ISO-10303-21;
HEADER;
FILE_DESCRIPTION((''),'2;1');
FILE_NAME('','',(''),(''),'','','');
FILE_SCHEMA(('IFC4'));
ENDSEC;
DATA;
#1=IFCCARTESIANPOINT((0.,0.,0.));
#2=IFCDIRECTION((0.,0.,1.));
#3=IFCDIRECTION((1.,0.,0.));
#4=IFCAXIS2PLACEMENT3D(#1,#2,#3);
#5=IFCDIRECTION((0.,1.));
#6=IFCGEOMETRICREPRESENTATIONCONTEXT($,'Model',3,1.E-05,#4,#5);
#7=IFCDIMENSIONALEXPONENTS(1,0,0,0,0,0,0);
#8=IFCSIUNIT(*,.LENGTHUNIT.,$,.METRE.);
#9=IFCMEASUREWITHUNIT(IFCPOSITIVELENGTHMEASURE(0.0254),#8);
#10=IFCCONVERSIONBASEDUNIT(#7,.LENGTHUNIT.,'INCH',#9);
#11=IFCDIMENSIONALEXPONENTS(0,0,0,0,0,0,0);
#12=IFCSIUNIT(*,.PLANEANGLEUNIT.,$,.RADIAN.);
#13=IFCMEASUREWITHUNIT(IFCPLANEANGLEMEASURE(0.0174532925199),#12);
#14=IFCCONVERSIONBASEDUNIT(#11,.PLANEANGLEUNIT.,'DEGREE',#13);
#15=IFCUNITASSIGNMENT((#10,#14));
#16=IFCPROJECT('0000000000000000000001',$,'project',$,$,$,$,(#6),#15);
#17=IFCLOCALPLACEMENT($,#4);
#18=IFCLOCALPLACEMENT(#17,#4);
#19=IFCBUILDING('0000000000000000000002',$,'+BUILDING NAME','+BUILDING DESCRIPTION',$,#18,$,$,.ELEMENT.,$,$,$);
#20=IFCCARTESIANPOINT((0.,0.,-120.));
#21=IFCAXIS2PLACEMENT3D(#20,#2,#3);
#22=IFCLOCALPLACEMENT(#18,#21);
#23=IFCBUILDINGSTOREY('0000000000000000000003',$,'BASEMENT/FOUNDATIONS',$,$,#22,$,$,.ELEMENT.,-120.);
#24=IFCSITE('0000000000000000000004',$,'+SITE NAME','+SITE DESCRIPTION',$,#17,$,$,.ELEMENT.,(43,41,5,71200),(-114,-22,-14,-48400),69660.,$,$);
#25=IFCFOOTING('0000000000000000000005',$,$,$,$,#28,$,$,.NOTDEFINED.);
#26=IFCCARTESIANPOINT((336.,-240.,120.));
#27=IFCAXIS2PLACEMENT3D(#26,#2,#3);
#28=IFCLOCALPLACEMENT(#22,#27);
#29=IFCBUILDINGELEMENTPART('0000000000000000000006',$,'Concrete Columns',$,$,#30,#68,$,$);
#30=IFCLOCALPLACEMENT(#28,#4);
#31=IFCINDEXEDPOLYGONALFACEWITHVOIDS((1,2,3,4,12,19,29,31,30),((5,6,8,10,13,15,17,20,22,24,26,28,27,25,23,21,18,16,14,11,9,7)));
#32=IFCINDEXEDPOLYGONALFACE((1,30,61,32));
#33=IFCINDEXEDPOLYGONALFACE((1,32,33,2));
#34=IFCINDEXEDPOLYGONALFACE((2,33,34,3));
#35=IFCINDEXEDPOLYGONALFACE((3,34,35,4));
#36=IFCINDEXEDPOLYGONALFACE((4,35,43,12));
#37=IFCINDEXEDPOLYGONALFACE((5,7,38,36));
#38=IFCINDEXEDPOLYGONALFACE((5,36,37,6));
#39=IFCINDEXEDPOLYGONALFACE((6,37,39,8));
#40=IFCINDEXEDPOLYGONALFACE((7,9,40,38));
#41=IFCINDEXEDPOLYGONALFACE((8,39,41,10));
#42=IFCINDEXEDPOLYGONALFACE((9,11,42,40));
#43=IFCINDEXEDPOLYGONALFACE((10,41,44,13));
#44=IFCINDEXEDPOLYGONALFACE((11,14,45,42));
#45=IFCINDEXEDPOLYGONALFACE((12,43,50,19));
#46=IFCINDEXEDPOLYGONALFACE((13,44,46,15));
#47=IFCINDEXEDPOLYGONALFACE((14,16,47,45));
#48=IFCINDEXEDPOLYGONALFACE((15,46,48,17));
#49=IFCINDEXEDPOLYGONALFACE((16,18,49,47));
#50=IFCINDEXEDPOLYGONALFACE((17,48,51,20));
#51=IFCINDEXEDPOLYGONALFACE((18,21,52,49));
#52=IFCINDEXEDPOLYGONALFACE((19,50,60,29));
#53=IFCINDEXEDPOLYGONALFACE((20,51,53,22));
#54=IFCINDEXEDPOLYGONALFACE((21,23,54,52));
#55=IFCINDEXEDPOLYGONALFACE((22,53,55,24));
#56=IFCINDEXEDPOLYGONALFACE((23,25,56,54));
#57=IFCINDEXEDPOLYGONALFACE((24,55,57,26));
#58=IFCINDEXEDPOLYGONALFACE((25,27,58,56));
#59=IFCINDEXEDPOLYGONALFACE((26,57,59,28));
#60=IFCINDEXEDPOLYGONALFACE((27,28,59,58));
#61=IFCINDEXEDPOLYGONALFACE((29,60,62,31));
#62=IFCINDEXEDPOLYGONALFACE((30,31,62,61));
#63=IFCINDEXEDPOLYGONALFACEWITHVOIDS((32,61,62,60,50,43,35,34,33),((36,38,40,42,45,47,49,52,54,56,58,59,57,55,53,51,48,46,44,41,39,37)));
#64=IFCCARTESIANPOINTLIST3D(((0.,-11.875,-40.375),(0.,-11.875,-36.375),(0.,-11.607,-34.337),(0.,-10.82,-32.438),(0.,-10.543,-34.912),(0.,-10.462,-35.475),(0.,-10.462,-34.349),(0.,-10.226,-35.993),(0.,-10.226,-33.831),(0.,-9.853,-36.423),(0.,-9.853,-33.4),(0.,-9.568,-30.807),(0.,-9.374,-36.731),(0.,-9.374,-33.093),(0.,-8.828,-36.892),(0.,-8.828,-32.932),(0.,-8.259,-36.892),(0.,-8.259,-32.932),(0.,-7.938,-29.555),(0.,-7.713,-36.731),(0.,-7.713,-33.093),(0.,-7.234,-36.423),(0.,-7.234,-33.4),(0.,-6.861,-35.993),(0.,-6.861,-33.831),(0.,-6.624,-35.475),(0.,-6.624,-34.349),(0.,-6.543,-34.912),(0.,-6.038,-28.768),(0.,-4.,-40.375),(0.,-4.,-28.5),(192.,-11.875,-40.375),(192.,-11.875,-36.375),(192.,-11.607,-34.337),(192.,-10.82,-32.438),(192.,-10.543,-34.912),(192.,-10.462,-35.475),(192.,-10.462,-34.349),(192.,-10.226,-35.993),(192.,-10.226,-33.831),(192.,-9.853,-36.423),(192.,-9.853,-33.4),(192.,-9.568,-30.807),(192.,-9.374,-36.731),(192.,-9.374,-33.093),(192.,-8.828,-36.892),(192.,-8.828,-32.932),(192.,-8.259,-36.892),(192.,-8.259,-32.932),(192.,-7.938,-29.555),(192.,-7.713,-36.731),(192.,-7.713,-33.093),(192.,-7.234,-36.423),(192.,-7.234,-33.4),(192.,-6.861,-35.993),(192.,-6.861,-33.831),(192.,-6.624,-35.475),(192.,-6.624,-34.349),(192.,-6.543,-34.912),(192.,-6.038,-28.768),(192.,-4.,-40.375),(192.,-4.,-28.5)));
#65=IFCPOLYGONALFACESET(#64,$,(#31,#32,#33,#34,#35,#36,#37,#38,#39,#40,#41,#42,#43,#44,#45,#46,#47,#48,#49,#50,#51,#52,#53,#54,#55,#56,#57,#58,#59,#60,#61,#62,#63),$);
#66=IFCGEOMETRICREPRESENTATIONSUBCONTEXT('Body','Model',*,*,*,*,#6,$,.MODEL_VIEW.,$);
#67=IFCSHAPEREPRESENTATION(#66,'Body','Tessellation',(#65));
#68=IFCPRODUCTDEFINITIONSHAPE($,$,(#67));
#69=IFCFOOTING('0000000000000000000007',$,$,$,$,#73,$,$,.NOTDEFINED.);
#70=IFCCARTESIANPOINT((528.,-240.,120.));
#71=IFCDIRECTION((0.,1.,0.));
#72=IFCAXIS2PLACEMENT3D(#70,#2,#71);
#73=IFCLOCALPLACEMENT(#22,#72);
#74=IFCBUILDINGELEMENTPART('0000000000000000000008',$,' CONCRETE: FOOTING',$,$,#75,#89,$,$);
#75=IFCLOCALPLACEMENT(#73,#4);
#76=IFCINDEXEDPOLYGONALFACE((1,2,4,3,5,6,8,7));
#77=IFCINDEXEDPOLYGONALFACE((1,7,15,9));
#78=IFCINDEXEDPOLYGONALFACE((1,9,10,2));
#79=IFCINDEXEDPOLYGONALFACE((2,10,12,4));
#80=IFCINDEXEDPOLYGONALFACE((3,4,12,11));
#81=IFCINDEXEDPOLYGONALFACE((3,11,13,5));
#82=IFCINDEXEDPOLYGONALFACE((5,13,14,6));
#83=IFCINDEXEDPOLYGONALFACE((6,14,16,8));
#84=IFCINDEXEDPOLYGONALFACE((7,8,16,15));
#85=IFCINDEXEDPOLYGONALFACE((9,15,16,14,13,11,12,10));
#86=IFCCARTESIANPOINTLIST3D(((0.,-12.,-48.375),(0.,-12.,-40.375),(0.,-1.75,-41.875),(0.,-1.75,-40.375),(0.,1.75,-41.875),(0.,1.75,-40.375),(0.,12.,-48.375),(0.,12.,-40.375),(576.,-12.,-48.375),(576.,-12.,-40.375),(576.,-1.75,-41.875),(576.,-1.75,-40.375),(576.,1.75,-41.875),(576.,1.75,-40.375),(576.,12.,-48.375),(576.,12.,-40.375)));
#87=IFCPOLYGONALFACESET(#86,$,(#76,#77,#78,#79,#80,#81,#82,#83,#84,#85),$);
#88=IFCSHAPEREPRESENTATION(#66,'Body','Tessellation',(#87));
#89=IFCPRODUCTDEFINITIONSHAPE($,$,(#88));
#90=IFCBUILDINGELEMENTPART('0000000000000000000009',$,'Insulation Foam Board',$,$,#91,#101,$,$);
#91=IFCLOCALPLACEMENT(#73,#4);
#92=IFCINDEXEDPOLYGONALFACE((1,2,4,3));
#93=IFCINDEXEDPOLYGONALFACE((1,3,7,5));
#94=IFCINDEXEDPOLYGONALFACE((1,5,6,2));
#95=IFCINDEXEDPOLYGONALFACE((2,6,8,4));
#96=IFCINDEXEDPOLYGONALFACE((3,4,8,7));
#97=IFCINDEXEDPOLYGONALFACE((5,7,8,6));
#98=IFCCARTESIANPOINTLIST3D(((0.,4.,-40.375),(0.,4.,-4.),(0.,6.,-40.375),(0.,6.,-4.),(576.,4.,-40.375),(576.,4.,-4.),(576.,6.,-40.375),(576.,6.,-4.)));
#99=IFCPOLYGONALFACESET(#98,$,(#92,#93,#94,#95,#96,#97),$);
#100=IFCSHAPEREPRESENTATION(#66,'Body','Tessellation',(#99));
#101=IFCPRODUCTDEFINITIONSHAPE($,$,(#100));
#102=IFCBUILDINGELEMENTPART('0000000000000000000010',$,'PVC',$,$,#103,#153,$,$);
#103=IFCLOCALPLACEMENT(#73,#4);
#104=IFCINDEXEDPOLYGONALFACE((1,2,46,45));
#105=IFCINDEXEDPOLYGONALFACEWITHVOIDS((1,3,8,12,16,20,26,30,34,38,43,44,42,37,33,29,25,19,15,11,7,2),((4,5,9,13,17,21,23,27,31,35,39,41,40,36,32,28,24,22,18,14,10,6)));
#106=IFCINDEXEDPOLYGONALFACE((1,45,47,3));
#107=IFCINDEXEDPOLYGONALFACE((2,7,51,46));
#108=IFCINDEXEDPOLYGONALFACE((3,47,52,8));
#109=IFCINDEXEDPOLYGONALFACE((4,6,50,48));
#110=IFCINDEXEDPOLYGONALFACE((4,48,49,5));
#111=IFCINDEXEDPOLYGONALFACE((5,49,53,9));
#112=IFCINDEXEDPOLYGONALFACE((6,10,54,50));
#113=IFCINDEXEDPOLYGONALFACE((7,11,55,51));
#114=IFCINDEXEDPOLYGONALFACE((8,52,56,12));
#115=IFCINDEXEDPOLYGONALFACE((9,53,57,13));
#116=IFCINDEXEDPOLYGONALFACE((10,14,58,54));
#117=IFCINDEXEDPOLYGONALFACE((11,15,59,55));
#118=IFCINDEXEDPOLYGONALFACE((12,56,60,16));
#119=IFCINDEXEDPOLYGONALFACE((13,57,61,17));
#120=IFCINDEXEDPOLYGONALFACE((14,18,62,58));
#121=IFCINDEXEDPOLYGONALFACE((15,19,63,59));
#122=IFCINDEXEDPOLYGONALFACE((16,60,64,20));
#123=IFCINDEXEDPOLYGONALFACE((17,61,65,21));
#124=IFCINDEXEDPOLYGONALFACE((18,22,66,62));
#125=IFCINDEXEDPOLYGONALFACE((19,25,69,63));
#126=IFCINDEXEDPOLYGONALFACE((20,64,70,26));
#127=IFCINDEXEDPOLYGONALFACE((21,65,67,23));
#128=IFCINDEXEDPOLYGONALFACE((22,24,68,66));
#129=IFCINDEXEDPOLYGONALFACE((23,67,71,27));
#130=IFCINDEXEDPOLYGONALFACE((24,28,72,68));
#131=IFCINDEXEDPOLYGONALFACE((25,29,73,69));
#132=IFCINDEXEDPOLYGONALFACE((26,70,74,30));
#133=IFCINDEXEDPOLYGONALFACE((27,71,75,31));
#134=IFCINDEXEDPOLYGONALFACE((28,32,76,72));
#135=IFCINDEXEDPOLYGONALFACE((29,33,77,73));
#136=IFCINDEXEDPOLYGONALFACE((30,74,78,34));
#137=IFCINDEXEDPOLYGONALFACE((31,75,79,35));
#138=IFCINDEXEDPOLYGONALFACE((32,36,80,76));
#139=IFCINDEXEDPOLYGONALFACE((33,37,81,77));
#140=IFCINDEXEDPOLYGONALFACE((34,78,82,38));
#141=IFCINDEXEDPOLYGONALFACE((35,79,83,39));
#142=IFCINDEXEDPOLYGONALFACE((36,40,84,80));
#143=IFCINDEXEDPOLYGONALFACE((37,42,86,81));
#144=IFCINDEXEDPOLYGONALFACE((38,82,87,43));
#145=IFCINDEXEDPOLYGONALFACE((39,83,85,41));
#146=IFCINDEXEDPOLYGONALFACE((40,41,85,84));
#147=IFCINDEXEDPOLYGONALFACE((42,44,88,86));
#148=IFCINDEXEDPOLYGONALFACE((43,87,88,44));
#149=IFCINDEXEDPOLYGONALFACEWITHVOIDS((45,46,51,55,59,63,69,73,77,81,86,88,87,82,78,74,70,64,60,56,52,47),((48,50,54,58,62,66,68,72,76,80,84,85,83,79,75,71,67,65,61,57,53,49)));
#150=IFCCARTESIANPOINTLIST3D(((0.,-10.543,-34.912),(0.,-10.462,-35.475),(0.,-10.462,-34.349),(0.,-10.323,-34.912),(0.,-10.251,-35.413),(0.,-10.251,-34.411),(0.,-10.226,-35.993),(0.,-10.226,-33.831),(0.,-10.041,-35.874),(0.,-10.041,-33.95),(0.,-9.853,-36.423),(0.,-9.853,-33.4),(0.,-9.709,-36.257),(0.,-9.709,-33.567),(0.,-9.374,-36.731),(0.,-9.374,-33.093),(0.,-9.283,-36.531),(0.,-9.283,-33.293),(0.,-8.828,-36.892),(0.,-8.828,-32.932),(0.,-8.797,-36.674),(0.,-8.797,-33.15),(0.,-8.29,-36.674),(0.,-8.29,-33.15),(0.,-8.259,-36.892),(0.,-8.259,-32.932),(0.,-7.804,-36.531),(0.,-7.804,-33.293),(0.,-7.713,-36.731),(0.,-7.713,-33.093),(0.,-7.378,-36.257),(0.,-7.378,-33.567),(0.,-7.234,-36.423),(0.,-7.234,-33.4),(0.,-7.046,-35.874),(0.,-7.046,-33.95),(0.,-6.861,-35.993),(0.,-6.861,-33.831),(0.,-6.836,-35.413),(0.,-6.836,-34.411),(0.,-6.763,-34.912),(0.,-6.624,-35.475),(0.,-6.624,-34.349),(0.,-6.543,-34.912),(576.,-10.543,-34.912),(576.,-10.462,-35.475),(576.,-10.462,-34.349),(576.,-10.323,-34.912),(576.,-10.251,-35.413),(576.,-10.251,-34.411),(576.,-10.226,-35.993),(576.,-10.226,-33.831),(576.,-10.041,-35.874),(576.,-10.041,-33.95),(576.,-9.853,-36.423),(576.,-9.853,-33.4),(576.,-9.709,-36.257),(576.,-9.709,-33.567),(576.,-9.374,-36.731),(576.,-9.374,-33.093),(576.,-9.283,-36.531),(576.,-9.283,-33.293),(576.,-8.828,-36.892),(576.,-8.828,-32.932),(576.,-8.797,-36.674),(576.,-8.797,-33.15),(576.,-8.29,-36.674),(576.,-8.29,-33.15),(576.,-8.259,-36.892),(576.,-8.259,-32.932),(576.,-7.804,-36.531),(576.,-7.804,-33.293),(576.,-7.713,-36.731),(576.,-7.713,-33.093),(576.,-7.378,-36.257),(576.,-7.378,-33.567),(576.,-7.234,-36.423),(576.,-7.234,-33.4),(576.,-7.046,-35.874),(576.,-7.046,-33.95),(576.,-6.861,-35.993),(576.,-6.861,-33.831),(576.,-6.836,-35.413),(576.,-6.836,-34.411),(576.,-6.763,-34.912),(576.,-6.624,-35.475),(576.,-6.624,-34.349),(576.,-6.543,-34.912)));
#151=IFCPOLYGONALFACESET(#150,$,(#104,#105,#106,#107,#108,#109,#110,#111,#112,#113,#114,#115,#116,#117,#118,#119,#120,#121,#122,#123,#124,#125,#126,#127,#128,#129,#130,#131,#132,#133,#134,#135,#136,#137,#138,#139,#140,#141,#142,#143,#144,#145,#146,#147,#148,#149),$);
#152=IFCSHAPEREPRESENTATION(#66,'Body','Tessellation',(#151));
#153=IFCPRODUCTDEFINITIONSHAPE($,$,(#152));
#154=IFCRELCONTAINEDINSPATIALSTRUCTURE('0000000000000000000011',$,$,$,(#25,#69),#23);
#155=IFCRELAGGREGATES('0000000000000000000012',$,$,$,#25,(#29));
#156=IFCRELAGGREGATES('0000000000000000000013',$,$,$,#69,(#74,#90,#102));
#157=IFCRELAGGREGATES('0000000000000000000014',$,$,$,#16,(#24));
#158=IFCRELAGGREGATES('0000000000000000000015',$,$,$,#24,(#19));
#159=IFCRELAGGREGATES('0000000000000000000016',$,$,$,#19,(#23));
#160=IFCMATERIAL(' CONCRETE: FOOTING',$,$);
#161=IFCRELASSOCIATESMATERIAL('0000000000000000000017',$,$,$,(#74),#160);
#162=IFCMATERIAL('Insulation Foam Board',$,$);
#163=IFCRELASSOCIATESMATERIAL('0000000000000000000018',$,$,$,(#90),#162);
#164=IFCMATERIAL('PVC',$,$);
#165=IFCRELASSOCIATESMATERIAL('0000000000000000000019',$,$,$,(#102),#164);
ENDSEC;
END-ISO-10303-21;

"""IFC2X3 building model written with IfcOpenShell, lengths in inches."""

from ifc_helpers import new_model, entity, si_unit, converted_unit, point, direction, frame, frame_2d, origin_with_axes, place, context, subcontext, project, spatial, polyline, circle_curve, parameter, trimmed, segment, composite_curve, outline, extrude, material, element, aggregate, save


model = new_model("IFC2X3")

# Units and contexts
model_context = context("Model", 3, precision=1e-05, world=origin_with_axes(), true_north=direction((0.0, 1.0)))
body_context = subcontext(model_context, "Body", "Model", "MODEL_VIEW")
ifc_project = project(units=[converted_unit("LENGTHUNIT", "INCH", entity("IfcPositiveLengthMeasure", 0.0254), si_unit("LENGTHUNIT", "METRE"), dimensions=[1, 0, 0, 0, 0, 0, 0]), converted_unit("PLANEANGLEUNIT", "DEGREE", entity("IfcPlaneAngleMeasure", 0.0174532925199), si_unit("PLANEANGLEUNIT", "RADIAN"), dimensions=[0, 0, 0, 0, 0, 0, 0])], contexts=[model_context])

# Site, building, storey
site_placement = place(None, origin_with_axes())
site = spatial("IfcSite", under=ifc_project, at=site_placement, Name="+SITE NAME", Description="+SITE DESCRIPTION", CompositionType="ELEMENT", RefLatitude=(43, 41, 5, 71200), RefLongitude=(-114, -22, -14, -48400), RefElevation=69660.0)
building_placement = place(site_placement, origin_with_axes())
building = spatial("IfcBuilding", under=site, at=building_placement, Name="+BUILDING NAME", Description="+BUILDING DESCRIPTION", CompositionType="ELEMENT")
storey_placement = place(building_placement, frame((0.0, 0.0, -120.0), z_axis=(0.0, 0.0, 1.0), x_axis=(1.0, 0.0, 0.0)))
storey = spatial("IfcBuildingStorey", under=building, at=storey_placement, Name="BASEMENT/FOUNDATIONS", CompositionType="ELEMENT", Elevation=-120.0)

# Footings, building element parts
ifc_material_1 = material(Name=" CONCRETE: FOOTING")
ifc_material_2 = material(Name="Insulation Foam Board")
ifc_material_3 = material(Name="PVC")
footing_1_placement = place(storey_placement, frame((336.0, -240.0, 120.0), z_axis=(0.0, 0.0, 1.0), x_axis=(1.0, 0.0, 0.0)))
footing_1 = element("IfcFooting", 1, at=footing_1_placement, inside=storey, PredefinedType="NOTDEFINED")
building_element_part_1_placement = place(footing_1_placement, origin_with_axes())
building_element_part_1 = element("IfcBuildingElementPart", 2, at=building_element_part_1_placement, Name="Concrete Columns", context=body_context, shape_type="SweptSolid", body=[
    extrude(outline(composite_curve([segment(trimmed(circle_curve(frame_2d((4.0, -36.375), x_axis=(1.0, 0.0)), 7.875), [point((11.875, -36.375)), parameter(0.0)], [point((4.0, -28.5)), parameter(90.0)], True, "CARTESIAN"), True, "CONTINUOUS"), segment(polyline([(4.0, -28.5), (4.0, -40.375), (11.875, -40.375), (11.875, -36.375)]), True, "CONTINUOUS")], self_intersect=False), holes=[composite_curve([segment(trimmed(circle_curve(frame_2d((8.543, -34.912), x_axis=(-1.0, 0.0)), 2.0), [point((10.543, -34.912)), parameter(180.0)], [point((6.543, -34.912)), parameter(0.0)], False, "CARTESIAN"), True, "CONTINUOUS"), segment(trimmed(circle_curve(frame_2d((8.543, -34.912), x_axis=(1.0, 0.0)), 2.0), [point((6.543, -34.912)), parameter(180.0)], [point((10.543, -34.912)), parameter(0.0)], False, "CARTESIAN"), True, "CONTINUOUS")], self_intersect=False)]), frame((0.0, 0.0, 0.0), z_axis=(-1.0, 0.0, 0.0), x_axis=(0.0, -1.0, 0.0)), (0.0, 0.0, -1.0), 192.0),
])
aggregate(footing_1, [building_element_part_1])
footing_2_placement = place(storey_placement, frame((528.0, -240.0, 120.0), z_axis=(0.0, 0.0, 1.0), x_axis=(0.0, 1.0, 0.0)))
footing_2 = element("IfcFooting", 3, at=footing_2_placement, inside=storey, PredefinedType="NOTDEFINED")
building_element_part_2_placement = place(footing_2_placement, origin_with_axes())
building_element_part_2 = element("IfcBuildingElementPart", 4, at=building_element_part_2_placement, material=ifc_material_1, Name=" CONCRETE: FOOTING", context=body_context, shape_type="SweptSolid", body=[
    extrude(outline(polyline([(-12.0, -48.375), (12.0, -48.375), (12.0, -40.375), (1.75, -40.375), (1.75, -41.875), (-1.75, -41.875), (-1.75, -40.375), (-12.0, -40.375), (-12.0, -48.375)])), frame((0.0, 0.0, 0.0), z_axis=(-1.0, 0.0, 0.0), x_axis=(0.0, -1.0, 0.0)), (0.0, 0.0, -1.0), 576.0),
])
building_element_part_3_placement = place(footing_2_placement, origin_with_axes())
building_element_part_3 = element("IfcBuildingElementPart", 5, at=building_element_part_3_placement, material=ifc_material_2, Name="Insulation Foam Board", context=body_context, shape_type="SweptSolid", body=[
    extrude(outline(polyline([(-4.0, -4.0), (-6.0, -4.0), (-6.0, -40.375), (-4.0, -40.375), (-4.0, -4.0)])), frame((0.0, 0.0, 0.0), z_axis=(-1.0, 0.0, 0.0), x_axis=(0.0, -1.0, 0.0)), (0.0, 0.0, -1.0), 576.0),
])
building_element_part_4_placement = place(footing_2_placement, origin_with_axes())
building_element_part_4 = element("IfcBuildingElementPart", 6, at=building_element_part_4_placement, material=ifc_material_3, Name="PVC", context=body_context, shape_type="SweptSolid", body=[
    extrude(outline(composite_curve([segment(trimmed(circle_curve(frame_2d((8.543, -34.912), x_axis=(1.0, 0.0)), 2.0), [point((10.543, -34.912)), parameter(0.0)], [point((6.543, -34.912)), parameter(180.0)], True, "CARTESIAN"), True, "CONTINUOUS"), segment(trimmed(circle_curve(frame_2d((8.543, -34.912), x_axis=(-1.0, 0.0)), 2.0), [point((6.543, -34.912)), parameter(0.0)], [point((10.543, -34.912)), parameter(180.0)], True, "CARTESIAN"), True, "CONTINUOUS")], self_intersect=False), holes=[composite_curve([segment(trimmed(circle_curve(frame_2d((8.543, -34.912), x_axis=(-1.0, 0.0)), 1.78), [point((10.323, -34.912)), parameter(180.0)], [point((6.763, -34.912)), parameter(0.0)], False, "CARTESIAN"), True, "CONTINUOUS"), segment(trimmed(circle_curve(frame_2d((8.543, -34.912), x_axis=(1.0, 0.0)), 1.78), [point((6.763, -34.912)), parameter(180.0)], [point((10.323, -34.912)), parameter(0.0)], False, "CARTESIAN"), True, "CONTINUOUS")], self_intersect=False)]), frame((0.0, 0.0, 0.0), z_axis=(-1.0, 0.0, 0.0), x_axis=(0.0, -1.0, 0.0)), (0.0, 0.0, -1.0), 576.0),
])
aggregate(footing_2, [building_element_part_2, building_element_part_3, building_element_part_4])

save(model, "model.ifc")
